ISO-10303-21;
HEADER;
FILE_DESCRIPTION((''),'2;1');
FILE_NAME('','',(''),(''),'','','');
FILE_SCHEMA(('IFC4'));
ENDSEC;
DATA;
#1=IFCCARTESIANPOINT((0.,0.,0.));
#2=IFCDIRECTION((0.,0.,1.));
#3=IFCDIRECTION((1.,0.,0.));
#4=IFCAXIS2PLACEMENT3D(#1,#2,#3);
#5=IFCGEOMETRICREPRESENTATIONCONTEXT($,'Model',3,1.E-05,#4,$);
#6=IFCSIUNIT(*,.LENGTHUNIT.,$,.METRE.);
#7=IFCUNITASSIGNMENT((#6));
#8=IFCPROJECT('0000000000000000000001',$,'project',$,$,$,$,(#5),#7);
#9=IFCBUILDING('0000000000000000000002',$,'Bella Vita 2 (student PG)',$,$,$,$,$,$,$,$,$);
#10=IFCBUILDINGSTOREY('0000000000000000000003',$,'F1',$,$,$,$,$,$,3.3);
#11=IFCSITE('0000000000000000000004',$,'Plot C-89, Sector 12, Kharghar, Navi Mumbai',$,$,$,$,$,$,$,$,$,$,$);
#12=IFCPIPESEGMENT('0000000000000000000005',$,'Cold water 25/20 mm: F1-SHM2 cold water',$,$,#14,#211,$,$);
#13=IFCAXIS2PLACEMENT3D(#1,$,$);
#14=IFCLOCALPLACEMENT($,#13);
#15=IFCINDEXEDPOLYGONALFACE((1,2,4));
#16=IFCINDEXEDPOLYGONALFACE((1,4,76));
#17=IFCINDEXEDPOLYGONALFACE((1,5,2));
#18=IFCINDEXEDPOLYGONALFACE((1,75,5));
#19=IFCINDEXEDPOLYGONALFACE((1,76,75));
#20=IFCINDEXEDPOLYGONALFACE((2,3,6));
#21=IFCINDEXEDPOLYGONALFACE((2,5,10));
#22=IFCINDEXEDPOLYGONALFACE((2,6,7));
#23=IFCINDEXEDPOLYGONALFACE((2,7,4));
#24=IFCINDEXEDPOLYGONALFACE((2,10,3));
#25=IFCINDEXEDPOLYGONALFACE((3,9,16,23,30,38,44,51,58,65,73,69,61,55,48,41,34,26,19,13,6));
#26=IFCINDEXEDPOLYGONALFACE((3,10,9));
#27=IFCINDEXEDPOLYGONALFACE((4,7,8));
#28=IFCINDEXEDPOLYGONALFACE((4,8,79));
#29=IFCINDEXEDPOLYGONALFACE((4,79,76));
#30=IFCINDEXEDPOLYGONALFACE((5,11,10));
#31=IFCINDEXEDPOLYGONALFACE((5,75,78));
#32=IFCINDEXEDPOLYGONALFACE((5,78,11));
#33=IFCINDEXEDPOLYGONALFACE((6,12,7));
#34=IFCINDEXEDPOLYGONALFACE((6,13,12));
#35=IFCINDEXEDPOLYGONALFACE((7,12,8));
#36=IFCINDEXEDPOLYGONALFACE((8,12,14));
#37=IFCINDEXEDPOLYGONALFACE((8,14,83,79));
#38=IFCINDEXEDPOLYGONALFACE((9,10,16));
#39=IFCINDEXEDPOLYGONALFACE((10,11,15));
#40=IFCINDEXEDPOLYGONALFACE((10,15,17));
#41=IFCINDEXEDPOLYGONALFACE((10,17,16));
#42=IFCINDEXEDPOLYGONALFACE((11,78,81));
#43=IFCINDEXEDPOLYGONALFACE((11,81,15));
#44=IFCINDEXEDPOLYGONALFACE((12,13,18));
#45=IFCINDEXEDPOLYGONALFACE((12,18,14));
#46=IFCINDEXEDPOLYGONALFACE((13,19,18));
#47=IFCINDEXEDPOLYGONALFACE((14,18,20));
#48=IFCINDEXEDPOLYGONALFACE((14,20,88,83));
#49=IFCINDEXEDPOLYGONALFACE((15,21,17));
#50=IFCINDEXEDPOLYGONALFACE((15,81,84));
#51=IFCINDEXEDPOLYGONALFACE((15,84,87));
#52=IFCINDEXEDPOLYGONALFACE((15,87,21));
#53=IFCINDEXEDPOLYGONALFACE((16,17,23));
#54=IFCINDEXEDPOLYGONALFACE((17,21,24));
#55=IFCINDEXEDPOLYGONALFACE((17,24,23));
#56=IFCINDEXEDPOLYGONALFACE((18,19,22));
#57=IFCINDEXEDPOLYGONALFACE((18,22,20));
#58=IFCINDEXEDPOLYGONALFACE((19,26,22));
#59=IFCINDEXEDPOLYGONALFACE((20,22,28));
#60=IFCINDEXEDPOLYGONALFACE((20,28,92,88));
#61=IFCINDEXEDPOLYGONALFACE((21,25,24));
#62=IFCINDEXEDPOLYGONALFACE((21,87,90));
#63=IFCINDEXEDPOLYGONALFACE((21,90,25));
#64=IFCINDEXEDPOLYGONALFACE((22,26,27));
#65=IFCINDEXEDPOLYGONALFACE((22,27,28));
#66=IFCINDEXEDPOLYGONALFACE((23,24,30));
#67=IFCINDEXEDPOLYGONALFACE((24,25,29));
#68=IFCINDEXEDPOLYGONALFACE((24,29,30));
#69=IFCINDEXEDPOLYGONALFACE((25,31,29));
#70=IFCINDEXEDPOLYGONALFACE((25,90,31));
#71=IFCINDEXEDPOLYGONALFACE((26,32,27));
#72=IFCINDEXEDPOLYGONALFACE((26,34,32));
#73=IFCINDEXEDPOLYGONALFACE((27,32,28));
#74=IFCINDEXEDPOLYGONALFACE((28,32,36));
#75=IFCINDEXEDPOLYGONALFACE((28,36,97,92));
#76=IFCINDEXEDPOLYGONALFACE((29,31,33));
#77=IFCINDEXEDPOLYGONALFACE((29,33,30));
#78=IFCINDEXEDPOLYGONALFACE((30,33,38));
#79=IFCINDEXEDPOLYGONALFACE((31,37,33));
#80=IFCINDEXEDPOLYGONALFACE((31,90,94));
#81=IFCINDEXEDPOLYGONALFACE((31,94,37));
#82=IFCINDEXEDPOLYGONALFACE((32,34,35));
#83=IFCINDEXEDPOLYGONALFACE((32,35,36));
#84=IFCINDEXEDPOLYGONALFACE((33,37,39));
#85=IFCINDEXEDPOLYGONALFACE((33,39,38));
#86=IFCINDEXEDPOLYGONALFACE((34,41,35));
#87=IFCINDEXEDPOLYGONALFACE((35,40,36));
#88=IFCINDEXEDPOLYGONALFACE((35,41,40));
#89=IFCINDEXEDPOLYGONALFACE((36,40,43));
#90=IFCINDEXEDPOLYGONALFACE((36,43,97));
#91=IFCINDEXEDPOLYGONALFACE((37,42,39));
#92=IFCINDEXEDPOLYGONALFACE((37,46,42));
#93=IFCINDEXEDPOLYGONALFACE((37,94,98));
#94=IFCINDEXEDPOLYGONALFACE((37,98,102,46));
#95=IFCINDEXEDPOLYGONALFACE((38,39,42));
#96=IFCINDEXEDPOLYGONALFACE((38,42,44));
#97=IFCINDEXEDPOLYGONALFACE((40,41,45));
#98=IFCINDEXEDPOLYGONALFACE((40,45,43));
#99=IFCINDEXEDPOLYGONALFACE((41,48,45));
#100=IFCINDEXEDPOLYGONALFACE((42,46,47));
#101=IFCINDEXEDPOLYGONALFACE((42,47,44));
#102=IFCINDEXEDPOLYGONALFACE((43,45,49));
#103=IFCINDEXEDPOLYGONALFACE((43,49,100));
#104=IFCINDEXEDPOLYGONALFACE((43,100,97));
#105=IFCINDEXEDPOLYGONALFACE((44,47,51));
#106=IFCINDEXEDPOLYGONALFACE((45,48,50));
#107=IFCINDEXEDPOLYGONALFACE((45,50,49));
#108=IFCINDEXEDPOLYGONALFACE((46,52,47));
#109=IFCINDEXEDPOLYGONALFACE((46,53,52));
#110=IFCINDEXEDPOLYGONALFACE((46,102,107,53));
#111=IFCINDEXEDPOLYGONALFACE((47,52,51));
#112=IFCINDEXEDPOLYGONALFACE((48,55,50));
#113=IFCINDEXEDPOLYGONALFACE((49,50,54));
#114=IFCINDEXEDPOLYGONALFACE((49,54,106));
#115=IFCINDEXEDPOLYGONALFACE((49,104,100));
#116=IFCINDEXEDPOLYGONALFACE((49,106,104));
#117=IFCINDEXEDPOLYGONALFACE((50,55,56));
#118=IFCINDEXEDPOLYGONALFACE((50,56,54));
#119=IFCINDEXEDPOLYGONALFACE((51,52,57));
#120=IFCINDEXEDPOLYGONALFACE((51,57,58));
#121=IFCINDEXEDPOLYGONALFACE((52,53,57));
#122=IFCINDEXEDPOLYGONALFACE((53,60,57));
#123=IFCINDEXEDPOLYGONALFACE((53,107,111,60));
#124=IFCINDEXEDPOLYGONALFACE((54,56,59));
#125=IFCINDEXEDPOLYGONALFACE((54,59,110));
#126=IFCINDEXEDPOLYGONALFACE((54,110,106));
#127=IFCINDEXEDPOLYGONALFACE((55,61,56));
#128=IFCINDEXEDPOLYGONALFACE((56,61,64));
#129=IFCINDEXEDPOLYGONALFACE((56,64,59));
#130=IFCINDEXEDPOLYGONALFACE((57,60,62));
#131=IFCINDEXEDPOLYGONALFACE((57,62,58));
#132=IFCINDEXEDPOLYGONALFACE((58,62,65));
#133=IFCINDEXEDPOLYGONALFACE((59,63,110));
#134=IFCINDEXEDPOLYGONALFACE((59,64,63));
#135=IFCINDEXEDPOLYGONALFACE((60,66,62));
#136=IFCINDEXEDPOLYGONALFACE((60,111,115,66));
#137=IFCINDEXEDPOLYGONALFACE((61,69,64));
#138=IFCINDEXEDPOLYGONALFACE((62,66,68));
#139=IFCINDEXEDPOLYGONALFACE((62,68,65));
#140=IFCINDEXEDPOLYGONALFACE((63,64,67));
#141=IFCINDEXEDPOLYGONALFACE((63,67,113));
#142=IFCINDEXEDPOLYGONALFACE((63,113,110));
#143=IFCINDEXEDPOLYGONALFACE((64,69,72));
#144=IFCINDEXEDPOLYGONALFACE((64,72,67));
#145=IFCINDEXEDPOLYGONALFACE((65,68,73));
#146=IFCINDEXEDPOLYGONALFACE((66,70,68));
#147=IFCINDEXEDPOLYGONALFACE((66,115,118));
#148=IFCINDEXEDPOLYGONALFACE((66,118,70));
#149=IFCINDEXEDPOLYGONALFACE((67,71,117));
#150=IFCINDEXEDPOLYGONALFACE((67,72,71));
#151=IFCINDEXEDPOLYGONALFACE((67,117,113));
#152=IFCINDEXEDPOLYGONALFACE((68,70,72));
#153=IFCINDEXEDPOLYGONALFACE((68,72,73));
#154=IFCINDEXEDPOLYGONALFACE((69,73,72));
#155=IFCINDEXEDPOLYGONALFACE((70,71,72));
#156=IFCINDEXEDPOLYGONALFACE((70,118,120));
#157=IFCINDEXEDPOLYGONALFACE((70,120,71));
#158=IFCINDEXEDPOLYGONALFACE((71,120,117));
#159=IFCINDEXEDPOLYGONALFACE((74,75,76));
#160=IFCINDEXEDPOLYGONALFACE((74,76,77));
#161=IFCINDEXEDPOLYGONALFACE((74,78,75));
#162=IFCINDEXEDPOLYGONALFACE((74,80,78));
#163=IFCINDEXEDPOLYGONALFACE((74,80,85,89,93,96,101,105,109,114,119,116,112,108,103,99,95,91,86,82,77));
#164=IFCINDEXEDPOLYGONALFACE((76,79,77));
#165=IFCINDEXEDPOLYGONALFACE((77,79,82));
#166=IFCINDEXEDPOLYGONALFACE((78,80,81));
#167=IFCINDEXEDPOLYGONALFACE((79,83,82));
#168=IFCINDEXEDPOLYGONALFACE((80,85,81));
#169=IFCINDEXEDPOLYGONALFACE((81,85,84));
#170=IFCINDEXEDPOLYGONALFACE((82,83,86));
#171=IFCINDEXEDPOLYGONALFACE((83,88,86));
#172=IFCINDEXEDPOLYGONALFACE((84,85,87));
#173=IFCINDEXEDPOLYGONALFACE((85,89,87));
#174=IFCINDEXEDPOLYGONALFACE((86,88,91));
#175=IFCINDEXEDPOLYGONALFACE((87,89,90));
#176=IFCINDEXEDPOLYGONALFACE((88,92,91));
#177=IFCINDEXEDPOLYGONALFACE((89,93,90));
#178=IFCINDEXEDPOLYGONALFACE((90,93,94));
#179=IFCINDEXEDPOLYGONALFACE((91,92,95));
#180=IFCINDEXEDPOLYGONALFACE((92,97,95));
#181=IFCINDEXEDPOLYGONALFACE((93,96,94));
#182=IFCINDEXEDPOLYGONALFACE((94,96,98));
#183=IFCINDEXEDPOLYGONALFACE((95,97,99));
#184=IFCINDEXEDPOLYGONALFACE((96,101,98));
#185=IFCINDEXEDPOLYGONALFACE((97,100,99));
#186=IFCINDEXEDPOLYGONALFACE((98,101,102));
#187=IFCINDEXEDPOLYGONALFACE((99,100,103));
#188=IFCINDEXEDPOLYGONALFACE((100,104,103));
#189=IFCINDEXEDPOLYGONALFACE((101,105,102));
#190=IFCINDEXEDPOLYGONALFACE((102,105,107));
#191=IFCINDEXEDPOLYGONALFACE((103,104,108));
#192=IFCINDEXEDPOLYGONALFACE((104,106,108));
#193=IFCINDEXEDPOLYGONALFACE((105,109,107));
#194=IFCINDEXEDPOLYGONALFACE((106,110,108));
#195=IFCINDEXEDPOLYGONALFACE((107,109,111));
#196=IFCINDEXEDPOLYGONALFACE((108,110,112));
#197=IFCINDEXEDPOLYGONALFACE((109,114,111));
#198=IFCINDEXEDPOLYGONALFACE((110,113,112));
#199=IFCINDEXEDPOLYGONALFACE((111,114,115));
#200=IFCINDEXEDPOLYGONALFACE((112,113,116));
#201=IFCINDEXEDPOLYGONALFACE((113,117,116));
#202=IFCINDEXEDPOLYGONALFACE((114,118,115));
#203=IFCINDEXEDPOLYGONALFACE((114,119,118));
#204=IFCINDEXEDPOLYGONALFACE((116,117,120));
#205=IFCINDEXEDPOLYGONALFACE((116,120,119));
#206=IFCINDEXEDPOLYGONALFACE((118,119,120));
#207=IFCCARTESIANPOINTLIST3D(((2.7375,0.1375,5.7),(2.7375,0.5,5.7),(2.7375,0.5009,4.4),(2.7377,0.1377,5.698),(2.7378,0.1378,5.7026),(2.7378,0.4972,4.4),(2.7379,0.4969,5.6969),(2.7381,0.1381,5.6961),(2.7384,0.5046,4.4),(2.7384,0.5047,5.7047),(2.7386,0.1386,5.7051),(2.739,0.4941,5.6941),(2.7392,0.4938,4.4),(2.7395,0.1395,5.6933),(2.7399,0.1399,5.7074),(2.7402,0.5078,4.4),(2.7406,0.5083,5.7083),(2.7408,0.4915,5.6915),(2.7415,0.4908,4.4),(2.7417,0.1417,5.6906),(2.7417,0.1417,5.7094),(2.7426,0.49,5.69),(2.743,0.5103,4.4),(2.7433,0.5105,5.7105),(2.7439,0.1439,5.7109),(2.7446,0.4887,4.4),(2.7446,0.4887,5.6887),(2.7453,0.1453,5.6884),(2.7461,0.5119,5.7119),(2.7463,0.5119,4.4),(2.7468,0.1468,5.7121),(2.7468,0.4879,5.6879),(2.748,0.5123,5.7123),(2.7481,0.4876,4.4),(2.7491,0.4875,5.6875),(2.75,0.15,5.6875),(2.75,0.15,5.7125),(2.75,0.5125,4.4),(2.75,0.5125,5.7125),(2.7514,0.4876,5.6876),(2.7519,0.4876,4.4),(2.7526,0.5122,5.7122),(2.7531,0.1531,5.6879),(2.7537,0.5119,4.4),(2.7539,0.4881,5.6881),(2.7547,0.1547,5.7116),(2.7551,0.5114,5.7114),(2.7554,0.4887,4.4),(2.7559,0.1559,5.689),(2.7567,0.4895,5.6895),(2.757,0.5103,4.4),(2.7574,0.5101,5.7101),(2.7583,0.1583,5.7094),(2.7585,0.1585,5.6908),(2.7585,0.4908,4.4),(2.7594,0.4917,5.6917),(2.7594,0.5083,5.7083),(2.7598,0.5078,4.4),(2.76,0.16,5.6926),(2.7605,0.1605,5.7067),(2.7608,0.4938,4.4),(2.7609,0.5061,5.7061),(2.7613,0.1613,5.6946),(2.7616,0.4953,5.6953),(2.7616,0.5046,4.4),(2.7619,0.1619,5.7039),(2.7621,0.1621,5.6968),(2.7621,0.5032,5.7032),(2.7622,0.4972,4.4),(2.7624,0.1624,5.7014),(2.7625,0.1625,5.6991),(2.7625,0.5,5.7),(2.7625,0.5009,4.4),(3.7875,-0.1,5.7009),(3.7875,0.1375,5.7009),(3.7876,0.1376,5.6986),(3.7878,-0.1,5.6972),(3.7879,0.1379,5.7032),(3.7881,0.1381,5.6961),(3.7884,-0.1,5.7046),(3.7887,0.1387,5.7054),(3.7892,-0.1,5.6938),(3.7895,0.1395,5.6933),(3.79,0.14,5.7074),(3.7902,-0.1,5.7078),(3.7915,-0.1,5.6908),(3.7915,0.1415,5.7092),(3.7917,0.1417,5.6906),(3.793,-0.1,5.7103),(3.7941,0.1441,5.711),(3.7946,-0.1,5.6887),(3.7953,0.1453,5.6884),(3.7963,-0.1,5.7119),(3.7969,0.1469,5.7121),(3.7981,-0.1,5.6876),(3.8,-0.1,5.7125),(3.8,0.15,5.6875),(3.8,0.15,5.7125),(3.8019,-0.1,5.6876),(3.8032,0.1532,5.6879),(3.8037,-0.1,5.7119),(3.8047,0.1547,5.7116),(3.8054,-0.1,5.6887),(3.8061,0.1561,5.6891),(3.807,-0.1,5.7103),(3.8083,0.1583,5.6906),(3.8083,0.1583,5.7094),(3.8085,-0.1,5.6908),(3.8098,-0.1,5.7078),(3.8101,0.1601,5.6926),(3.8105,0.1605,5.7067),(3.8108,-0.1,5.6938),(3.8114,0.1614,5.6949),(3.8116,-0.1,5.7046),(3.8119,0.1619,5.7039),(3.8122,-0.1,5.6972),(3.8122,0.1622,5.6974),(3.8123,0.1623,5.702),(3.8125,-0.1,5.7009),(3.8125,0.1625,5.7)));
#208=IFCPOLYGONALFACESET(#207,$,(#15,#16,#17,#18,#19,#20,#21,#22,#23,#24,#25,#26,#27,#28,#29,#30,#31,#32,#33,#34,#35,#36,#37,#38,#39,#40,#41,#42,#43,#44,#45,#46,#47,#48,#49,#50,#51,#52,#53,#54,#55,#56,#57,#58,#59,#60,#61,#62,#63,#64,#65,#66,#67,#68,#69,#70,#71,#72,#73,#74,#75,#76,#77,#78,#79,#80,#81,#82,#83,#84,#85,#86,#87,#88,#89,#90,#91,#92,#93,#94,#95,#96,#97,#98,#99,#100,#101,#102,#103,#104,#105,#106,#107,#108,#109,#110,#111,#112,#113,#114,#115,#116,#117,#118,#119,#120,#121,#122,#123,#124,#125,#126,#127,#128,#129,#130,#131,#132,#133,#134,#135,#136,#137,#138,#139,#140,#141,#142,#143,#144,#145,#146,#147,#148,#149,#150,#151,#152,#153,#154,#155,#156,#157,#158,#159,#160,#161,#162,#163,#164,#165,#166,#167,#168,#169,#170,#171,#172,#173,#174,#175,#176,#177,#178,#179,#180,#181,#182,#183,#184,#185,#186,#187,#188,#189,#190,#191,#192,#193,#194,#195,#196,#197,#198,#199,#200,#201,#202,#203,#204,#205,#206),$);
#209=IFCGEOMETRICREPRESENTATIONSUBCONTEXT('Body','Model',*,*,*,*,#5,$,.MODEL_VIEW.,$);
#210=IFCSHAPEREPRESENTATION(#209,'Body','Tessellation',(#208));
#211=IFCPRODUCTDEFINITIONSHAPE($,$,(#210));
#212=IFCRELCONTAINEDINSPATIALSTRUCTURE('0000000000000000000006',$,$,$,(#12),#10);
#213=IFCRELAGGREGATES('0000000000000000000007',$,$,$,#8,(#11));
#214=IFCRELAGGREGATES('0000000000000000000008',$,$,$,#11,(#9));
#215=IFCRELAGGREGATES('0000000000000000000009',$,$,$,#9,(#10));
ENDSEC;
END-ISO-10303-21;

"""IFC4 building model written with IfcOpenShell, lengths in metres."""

from ifc_helpers import new_model, entity, si_unit, origin, origin_with_axes, place, context, subcontext, project, spatial, element, save


model = new_model("IFC4")

# Units and contexts
model_context = context("Model", 3, precision=1e-05, world=origin_with_axes())
body_context = subcontext(model_context, "Body", "Model", "MODEL_VIEW")
ifc_project = project(units=[si_unit("LENGTHUNIT", "METRE")], contexts=[model_context])

# Site, building, storey
site = spatial("IfcSite", under=ifc_project, Name="Plot C-89, Sector 12, Kharghar, Navi Mumbai")
building = spatial("IfcBuilding", under=site, Name="Bella Vita 2 (student PG)")
storey = spatial("IfcBuildingStorey", under=building, Name="F1", Elevation=3.3)

# Pipe segment
pipe_segment_1_placement = place(None, origin())
element("IfcPipeSegment", 1, at=pipe_segment_1_placement, inside=storey, Name="Cold water 25/20 mm: F1-SHM2 cold water", context=body_context, shape_type="AdvancedSweptSolid", body=[
    entity("IfcSweptDiskSolid", entity("IfcPolyline", [entity("IfcCartesianPoint", [3.8, -0.1, 5.7]), entity("IfcCartesianPoint", [3.8, 0.15, 5.7]), entity("IfcCartesianPoint", [2.75, 0.15, 5.7]), entity("IfcCartesianPoint", [2.75, 0.5, 5.7]), entity("IfcCartesianPoint", [2.75, 0.5, 4.4])]), 0.0125),
])

save(model, "model.ifc")
